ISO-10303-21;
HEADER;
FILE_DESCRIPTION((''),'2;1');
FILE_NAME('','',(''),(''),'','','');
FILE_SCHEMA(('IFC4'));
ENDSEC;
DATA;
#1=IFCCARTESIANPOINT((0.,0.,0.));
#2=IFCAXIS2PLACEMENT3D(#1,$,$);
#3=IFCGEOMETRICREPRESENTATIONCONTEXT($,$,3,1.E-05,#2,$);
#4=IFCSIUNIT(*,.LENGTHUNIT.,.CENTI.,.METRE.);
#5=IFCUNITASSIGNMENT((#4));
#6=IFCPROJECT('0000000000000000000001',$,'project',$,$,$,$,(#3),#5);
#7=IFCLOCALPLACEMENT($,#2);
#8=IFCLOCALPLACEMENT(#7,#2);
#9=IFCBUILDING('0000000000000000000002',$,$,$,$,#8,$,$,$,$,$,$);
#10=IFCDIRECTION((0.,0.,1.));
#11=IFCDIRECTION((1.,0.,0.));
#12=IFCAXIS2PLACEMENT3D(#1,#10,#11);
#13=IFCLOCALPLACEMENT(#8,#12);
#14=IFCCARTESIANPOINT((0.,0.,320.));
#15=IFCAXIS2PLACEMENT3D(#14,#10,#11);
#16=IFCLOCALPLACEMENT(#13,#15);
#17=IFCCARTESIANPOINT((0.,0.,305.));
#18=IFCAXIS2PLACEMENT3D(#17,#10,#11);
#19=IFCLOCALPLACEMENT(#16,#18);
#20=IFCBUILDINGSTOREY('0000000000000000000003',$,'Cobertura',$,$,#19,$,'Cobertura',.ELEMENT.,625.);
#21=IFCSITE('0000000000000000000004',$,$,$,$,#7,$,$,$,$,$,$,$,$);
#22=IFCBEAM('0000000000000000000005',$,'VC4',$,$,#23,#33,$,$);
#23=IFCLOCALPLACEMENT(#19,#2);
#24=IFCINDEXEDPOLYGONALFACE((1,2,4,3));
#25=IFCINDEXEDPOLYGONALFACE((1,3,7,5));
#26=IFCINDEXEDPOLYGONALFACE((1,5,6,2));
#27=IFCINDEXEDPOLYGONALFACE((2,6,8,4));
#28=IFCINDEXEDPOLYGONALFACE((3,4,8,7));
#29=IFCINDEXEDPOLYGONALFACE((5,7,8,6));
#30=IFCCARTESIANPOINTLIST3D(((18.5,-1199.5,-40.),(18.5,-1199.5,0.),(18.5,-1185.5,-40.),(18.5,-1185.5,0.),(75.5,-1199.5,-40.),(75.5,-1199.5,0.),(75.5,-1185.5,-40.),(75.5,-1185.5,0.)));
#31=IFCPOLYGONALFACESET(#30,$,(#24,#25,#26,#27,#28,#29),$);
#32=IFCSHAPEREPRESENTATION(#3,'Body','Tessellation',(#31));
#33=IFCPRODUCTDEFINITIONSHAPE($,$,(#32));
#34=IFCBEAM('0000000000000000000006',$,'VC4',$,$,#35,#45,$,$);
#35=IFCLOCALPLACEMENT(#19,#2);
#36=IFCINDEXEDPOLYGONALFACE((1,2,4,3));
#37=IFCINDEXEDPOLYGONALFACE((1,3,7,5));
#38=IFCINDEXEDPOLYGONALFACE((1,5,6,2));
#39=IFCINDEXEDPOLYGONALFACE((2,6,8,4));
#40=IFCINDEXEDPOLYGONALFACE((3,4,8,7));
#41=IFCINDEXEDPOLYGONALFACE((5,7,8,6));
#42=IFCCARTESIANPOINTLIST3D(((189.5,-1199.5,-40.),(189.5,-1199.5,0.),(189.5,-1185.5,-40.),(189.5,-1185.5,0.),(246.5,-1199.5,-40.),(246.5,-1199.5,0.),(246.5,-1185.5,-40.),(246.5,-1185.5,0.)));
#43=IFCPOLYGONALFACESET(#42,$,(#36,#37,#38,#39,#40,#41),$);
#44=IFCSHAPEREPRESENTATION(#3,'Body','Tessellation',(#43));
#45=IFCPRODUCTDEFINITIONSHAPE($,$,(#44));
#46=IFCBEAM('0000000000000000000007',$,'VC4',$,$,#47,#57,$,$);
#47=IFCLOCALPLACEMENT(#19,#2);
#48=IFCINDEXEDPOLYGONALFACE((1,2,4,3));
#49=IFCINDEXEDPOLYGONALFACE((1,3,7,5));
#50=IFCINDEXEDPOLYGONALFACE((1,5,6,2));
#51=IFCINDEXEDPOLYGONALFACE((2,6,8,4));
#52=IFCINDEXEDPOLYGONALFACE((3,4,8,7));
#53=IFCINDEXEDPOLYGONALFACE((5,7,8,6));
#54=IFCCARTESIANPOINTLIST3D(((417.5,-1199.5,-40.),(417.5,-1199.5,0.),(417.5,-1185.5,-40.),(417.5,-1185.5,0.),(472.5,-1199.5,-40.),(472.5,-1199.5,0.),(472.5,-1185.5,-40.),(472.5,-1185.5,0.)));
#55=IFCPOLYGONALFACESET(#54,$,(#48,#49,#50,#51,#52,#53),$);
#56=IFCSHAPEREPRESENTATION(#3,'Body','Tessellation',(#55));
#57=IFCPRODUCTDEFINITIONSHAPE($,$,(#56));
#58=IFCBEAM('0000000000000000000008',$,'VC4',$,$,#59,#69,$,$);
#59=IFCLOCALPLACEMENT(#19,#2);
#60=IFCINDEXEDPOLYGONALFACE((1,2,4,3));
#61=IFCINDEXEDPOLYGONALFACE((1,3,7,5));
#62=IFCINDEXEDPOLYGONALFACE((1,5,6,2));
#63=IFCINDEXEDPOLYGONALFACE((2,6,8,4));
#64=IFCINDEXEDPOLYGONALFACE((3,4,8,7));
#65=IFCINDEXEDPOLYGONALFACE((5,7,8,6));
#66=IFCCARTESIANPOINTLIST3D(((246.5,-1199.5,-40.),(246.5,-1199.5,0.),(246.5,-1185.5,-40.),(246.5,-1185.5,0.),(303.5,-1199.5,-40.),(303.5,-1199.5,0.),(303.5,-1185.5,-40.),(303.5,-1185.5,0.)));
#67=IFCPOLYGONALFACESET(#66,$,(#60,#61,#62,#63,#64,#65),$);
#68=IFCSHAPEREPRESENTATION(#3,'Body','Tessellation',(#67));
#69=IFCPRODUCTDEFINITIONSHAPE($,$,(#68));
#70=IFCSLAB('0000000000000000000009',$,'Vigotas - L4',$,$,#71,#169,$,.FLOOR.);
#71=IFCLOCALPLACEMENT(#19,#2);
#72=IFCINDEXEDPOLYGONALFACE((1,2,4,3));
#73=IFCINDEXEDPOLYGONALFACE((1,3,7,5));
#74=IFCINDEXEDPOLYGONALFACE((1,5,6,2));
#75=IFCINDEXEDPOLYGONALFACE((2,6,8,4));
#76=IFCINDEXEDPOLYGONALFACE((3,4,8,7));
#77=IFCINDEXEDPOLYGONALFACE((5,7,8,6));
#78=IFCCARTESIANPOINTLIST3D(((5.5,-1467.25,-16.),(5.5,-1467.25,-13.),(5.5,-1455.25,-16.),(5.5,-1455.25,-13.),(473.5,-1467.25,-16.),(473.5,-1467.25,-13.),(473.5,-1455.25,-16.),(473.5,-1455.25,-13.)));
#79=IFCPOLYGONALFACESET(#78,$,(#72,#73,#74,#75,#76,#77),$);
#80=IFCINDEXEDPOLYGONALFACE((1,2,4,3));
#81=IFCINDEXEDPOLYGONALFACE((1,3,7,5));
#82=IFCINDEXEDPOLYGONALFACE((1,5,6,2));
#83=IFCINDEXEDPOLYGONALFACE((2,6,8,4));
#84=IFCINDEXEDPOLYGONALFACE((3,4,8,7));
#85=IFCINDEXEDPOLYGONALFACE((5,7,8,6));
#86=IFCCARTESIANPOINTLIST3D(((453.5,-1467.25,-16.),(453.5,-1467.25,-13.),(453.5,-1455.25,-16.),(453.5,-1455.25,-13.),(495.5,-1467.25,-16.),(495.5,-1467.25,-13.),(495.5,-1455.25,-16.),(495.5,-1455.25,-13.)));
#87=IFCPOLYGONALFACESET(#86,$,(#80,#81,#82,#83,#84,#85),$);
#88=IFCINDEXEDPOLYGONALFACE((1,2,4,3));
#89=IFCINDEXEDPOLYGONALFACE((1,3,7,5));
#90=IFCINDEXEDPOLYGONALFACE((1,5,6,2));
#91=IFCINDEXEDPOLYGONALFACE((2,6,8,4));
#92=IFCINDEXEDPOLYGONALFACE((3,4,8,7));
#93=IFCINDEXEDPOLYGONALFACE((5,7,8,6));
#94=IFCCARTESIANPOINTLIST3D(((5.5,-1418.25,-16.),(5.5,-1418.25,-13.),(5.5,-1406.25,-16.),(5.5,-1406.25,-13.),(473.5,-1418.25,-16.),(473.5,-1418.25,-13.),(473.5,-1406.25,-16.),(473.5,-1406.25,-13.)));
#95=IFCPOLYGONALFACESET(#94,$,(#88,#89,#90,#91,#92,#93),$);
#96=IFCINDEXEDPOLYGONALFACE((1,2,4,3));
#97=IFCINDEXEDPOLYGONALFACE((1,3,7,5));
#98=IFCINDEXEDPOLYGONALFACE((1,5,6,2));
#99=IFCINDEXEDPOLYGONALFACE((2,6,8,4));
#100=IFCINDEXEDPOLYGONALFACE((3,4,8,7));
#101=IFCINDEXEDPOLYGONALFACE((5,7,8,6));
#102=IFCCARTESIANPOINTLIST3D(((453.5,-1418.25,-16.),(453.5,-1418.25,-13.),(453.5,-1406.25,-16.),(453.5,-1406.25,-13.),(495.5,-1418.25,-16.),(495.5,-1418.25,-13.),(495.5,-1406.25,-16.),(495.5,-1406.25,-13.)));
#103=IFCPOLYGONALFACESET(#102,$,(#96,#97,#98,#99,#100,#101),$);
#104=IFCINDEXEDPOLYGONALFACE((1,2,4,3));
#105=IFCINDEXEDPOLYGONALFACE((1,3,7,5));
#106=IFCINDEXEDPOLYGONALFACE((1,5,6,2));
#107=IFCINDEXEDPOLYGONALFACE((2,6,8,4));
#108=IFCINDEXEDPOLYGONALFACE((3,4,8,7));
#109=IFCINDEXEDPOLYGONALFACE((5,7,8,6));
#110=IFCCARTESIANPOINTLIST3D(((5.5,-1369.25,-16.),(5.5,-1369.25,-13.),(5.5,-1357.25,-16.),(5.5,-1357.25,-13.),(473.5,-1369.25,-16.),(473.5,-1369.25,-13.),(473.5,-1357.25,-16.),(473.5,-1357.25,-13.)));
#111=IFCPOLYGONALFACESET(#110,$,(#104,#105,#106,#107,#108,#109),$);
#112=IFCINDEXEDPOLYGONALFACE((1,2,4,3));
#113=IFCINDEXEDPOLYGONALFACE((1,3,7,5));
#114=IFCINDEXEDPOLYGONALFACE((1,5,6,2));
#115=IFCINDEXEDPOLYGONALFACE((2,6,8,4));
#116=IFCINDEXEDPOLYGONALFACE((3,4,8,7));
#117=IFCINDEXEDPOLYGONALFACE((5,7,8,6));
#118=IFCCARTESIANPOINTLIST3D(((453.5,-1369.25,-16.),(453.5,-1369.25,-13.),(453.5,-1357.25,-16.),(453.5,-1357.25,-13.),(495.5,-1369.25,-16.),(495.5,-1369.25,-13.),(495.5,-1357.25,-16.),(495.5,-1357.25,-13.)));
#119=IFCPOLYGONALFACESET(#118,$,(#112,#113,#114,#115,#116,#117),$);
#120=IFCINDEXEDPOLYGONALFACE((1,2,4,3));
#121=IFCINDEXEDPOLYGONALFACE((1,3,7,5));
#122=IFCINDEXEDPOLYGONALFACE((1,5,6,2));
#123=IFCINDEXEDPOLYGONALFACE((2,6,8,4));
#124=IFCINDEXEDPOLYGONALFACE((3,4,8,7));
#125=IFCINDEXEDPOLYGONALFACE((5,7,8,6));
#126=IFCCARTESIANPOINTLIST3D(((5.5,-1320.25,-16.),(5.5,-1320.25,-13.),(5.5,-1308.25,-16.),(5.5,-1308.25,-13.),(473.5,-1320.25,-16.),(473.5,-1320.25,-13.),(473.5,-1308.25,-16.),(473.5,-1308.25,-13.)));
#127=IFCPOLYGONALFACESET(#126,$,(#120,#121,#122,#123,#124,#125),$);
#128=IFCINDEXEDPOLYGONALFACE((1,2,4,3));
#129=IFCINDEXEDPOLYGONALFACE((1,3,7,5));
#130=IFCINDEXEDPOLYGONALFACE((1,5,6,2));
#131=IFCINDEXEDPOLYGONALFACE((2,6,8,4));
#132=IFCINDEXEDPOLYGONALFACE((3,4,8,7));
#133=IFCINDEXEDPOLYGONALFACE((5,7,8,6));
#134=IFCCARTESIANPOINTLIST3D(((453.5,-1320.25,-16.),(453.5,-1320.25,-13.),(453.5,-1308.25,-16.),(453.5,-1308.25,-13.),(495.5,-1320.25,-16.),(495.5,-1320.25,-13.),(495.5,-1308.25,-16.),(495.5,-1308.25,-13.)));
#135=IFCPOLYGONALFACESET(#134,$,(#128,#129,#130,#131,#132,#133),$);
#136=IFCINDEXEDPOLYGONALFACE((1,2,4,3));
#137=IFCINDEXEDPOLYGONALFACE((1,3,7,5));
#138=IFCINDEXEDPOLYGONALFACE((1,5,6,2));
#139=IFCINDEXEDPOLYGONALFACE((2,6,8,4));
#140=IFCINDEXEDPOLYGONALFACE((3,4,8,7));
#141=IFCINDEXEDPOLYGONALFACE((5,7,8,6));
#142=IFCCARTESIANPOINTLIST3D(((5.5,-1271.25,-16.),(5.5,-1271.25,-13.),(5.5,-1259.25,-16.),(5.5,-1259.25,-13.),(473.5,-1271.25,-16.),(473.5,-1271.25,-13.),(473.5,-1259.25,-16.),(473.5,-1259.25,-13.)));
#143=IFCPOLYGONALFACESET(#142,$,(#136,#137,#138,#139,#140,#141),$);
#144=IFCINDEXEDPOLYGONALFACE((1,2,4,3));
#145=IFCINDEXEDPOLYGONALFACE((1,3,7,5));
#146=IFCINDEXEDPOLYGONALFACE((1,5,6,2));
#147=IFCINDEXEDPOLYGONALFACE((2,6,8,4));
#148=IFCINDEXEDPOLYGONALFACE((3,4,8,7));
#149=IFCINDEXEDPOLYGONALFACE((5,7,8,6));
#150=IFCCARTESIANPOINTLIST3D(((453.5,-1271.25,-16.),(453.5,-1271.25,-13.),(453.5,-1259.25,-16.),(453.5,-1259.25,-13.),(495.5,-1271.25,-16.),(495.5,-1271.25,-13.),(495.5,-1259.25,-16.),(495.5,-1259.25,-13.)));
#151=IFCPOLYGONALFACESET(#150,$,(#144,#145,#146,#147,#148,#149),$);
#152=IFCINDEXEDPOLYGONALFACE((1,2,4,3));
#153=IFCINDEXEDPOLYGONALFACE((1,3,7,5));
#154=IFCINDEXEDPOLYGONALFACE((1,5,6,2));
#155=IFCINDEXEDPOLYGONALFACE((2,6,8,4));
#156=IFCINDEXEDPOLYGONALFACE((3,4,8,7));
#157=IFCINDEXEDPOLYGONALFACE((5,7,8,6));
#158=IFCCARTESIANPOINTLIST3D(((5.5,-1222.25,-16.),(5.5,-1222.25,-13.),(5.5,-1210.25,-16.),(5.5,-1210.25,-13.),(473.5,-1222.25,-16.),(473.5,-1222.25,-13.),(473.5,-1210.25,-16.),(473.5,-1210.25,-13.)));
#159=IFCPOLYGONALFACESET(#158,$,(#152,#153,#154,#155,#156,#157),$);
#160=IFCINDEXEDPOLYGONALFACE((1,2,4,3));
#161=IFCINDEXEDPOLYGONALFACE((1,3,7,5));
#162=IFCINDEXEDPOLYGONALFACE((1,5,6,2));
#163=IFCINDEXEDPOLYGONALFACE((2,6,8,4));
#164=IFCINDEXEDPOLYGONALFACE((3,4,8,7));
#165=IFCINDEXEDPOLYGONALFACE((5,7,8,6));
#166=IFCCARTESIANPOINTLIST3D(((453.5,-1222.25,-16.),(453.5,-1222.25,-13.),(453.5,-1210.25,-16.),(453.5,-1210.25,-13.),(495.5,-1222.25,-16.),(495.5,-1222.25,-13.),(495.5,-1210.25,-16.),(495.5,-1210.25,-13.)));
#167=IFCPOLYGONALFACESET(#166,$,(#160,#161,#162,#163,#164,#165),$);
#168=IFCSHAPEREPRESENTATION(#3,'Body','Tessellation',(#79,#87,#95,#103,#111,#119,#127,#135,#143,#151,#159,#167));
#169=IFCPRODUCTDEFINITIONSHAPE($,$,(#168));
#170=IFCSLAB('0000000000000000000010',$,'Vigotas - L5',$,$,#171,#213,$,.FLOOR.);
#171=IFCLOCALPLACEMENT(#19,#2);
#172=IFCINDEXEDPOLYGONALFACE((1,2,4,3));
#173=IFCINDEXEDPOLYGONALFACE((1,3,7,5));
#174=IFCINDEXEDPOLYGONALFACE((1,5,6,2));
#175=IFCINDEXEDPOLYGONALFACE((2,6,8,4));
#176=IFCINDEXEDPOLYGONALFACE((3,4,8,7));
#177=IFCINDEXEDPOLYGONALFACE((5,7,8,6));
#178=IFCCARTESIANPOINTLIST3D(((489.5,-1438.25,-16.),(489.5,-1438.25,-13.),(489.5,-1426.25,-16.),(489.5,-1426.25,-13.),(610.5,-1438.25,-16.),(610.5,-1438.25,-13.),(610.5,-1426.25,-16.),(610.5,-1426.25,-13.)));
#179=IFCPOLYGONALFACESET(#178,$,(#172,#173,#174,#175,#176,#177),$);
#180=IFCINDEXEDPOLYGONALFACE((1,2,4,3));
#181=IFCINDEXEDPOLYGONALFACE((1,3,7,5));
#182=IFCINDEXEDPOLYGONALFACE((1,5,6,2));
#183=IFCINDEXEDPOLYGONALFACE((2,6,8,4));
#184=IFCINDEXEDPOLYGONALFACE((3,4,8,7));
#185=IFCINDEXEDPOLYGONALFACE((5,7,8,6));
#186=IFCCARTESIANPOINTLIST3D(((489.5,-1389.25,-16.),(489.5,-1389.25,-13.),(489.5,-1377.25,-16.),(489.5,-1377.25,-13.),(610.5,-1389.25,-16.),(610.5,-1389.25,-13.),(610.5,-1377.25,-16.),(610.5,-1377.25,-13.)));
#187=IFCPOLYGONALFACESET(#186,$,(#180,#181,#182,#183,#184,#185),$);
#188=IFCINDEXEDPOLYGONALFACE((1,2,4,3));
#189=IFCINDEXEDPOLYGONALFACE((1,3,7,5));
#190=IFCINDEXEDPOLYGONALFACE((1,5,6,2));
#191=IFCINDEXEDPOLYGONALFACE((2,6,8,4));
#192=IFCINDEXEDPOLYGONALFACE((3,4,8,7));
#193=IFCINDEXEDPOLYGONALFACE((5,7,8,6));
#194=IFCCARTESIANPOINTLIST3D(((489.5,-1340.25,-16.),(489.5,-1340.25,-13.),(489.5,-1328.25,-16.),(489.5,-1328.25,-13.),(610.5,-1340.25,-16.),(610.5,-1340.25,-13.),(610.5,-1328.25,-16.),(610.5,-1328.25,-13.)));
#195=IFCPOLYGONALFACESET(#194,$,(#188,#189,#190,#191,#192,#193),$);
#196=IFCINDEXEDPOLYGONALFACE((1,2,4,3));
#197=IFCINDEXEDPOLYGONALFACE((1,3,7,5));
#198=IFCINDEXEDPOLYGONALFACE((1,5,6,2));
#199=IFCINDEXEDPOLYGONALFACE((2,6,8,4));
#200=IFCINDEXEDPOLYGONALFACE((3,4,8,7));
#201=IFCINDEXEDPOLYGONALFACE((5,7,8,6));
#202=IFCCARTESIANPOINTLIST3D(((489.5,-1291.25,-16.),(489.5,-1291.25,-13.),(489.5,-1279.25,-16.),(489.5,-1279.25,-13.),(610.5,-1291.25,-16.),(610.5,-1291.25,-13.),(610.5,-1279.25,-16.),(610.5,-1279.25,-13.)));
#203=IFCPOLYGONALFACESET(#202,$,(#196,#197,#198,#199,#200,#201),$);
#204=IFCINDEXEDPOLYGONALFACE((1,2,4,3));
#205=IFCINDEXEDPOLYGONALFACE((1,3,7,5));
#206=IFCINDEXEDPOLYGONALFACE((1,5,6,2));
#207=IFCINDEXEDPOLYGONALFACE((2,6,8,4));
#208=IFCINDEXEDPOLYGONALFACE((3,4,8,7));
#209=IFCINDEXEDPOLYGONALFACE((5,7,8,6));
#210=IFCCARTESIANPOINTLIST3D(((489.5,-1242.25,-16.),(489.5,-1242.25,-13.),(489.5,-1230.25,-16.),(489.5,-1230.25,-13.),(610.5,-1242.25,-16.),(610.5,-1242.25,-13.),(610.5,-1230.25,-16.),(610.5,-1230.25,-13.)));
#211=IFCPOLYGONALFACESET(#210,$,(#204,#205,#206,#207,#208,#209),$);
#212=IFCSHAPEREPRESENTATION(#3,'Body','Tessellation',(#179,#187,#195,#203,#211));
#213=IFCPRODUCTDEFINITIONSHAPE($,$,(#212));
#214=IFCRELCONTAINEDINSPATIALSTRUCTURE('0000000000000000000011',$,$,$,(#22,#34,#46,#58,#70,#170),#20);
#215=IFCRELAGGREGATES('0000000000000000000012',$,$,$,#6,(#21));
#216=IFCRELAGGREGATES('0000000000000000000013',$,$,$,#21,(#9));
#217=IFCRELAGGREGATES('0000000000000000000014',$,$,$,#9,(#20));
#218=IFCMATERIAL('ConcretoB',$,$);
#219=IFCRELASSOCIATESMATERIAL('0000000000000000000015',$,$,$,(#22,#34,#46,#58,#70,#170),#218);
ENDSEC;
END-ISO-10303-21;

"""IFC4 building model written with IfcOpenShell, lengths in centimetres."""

from ifc_helpers import new_model, si_unit, frame, origin, origin_with_axes, place, context, project, spatial, polyline, outline, extrude, material, element, save


model = new_model("IFC4")

# Units and contexts
context_of_model = context(None, 3, precision=1e-05, world=origin())
ifc_project = project(units=[si_unit("LENGTHUNIT", "METRE", prefix="CENTI")], contexts=[context_of_model])

# Site, building, storey
site_placement = place(None, origin())
site = spatial("IfcSite", under=ifc_project, at=site_placement)
building_placement = place(site_placement, origin())
building = spatial("IfcBuilding", under=site, at=building_placement)
placement_1 = place(building_placement, origin_with_axes())
placement_2 = place(placement_1, frame((0.0, 0.0, 320.0), z_axis=(0.0, 0.0, 1.0), x_axis=(1.0, 0.0, 0.0)))
storey_placement = place(placement_2, frame((0.0, 0.0, 305.0), z_axis=(0.0, 0.0, 1.0), x_axis=(1.0, 0.0, 0.0)))
storey = spatial("IfcBuildingStorey", under=building, at=storey_placement, Name="Cobertura", LongName="Cobertura", CompositionType="ELEMENT", Elevation=625.0)

# Shared definitions
ifc_material_1 = material(Name="ConcretoB")

# Beams
for number, where, z_axis, x_axis, name in (
    (1, (47.0, -1192.5, 0.0), (0.0, 0.0, 1.0), (1.0, 0.0, 0.0), "VC4"),
    (2, (218.0, -1192.5, 0.0), (0.0, 0.0, 1.0), (1.0, 0.0, 0.0), "VC4"),
):
    element("IfcBeam", number, at=place(storey_placement, frame(where, z_axis=z_axis, x_axis=x_axis)), inside=storey, material=ifc_material_1, Name=name, context=context_of_model, shape_type="SolidModel", body=[
        extrude(outline(polyline([(-7.0, -20.0), (7.0, -20.0), (7.0, 20.0), (-7.0, 20.0), (-7.0, -20.0)])), frame((-28.5, 0.0, -20.0), z_axis=(1.0, 0.0, 0.0), x_axis=(0.0, -1.0, 0.0)), (0.0, 0.0, 1.0), 57.0),
    ])
beam_1_placement = place(storey_placement, frame((445.0, -1192.5, 0.0), z_axis=(0.0, 0.0, 1.0), x_axis=(1.0, 0.0, 0.0)))
element("IfcBeam", 3, at=beam_1_placement, inside=storey, material=ifc_material_1, Name="VC4", context=context_of_model, shape_type="SolidModel", body=[
    extrude(outline(polyline([(-7.0, -20.0), (7.0, -20.0), (7.0, 20.0), (-7.0, 20.0), (-7.0, -20.0)])), frame((-27.5, 0.0, -20.0), z_axis=(1.0, 0.0, 0.0), x_axis=(0.0, -1.0, 0.0)), (0.0, 0.0, 1.0), 55.0),
])
beam_2_placement = place(storey_placement, frame((275.0, -1192.5, 0.0), z_axis=(0.0, 0.0, 1.0), x_axis=(1.0, 0.0, 0.0)))
element("IfcBeam", 4, at=beam_2_placement, inside=storey, material=ifc_material_1, Name="VC4", context=context_of_model, shape_type="SolidModel", body=[
    extrude(outline(polyline([(-7.0, -20.0), (7.0, -20.0), (7.0, 20.0), (-7.0, 20.0), (-7.0, -20.0)])), frame((-28.5, 0.0, -20.0), z_axis=(1.0, 0.0, 0.0), x_axis=(0.0, -1.0, 0.0)), (0.0, 0.0, 1.0), 57.0),
])

# Slabs
slab_1_placement = place(storey_placement, frame((250.5, -1338.75, -13.0), z_axis=(0.0, 0.0, 1.0), x_axis=(1.0, 0.0, 0.0)))
element("IfcSlab", 5, at=slab_1_placement, inside=storey, material=ifc_material_1, Name="Vigotas - L4", PredefinedType="FLOOR", context=context_of_model, shape_type="SolidModel", body=[
    extrude(outline(polyline([(6.0, 1.5), (-6.0, 1.5), (-6.0, -1.5), (6.0, -1.5), (6.0, 1.5), (6.0, 1.5)])), frame((-245.0, -122.5, -1.5), z_axis=(1.0, 0.0, 0.0), x_axis=(0.0, -1.0, 0.0)), (0.0, 0.0, 1.0), 468.0),
    extrude(outline(polyline([(6.0, 1.5), (-6.0, 1.5), (-6.0, -1.5), (6.0, -1.5), (6.0, 1.5), (6.0, 1.5)])), frame((203.0, -122.5, -1.5), z_axis=(1.0, 0.0, 0.0), x_axis=(0.0, -1.0, 0.0)), (0.0, 0.0, 1.0), 42.0),
    extrude(outline(polyline([(6.0, 1.5), (-6.0, 1.5), (-6.0, -1.5), (6.0, -1.5), (6.0, 1.5), (6.0, 1.5)])), frame((-245.0, -73.5, -1.5), z_axis=(1.0, 0.0, 0.0), x_axis=(0.0, -1.0, 0.0)), (0.0, 0.0, 1.0), 468.0),
    extrude(outline(polyline([(6.0, 1.5), (-6.0, 1.5), (-6.0, -1.5), (6.0, -1.5), (6.0, 1.5), (6.0, 1.5)])), frame((203.0, -73.5, -1.5), z_axis=(1.0, 0.0, 0.0), x_axis=(0.0, -1.0, 0.0)), (0.0, 0.0, 1.0), 42.0),
    extrude(outline(polyline([(6.0, 1.5), (-6.0, 1.5), (-6.0, -1.5), (6.0, -1.5), (6.0, 1.5), (6.0, 1.5)])), frame((-245.0, -24.5, -1.5), z_axis=(1.0, 0.0, 0.0), x_axis=(0.0, -1.0, 0.0)), (0.0, 0.0, 1.0), 468.0),
    extrude(outline(polyline([(6.0, 1.5), (-6.0, 1.5), (-6.0, -1.5), (6.0, -1.5), (6.0, 1.5), (6.0, 1.5)])), frame((203.0, -24.5, -1.5), z_axis=(1.0, 0.0, 0.0), x_axis=(0.0, -1.0, 0.0)), (0.0, 0.0, 1.0), 42.0),
    extrude(outline(polyline([(6.0, 1.5), (-6.0, 1.5), (-6.0, -1.5), (6.0, -1.5), (6.0, 1.5), (6.0, 1.5)])), frame((-245.0, 24.5, -1.5), z_axis=(1.0, 0.0, 0.0), x_axis=(0.0, -1.0, 0.0)), (0.0, 0.0, 1.0), 468.0),
    extrude(outline(polyline([(6.0, 1.5), (-6.0, 1.5), (-6.0, -1.5), (6.0, -1.5), (6.0, 1.5), (6.0, 1.5)])), frame((203.0, 24.5, -1.5), z_axis=(1.0, 0.0, 0.0), x_axis=(0.0, -1.0, 0.0)), (0.0, 0.0, 1.0), 42.0),
    extrude(outline(polyline([(6.0, 1.5), (-6.0, 1.5), (-6.0, -1.5), (6.0, -1.5), (6.0, 1.5), (6.0, 1.5)])), frame((-245.0, 73.5, -1.5), z_axis=(1.0, 0.0, 0.0), x_axis=(0.0, -1.0, 0.0)), (0.0, 0.0, 1.0), 468.0),
    extrude(outline(polyline([(6.0, 1.5), (-6.0, 1.5), (-6.0, -1.5), (6.0, -1.5), (6.0, 1.5), (6.0, 1.5)])), frame((203.0, 73.5, -1.5), z_axis=(1.0, 0.0, 0.0), x_axis=(0.0, -1.0, 0.0)), (0.0, 0.0, 1.0), 42.0),
    extrude(outline(polyline([(6.0, 1.5), (-6.0, 1.5), (-6.0, -1.5), (6.0, -1.5), (6.0, 1.5), (6.0, 1.5)])), frame((-245.0, 122.5, -1.5), z_axis=(1.0, 0.0, 0.0), x_axis=(0.0, -1.0, 0.0)), (0.0, 0.0, 1.0), 468.0),
    extrude(outline(polyline([(6.0, 1.5), (-6.0, 1.5), (-6.0, -1.5), (6.0, -1.5), (6.0, 1.5), (6.0, 1.5)])), frame((203.0, 122.5, -1.5), z_axis=(1.0, 0.0, 0.0), x_axis=(0.0, -1.0, 0.0)), (0.0, 0.0, 1.0), 42.0),
])
slab_2_placement = place(storey_placement, frame((550.0, -1334.25, -13.0), z_axis=(0.0, 0.0, 1.0), x_axis=(1.0, 0.0, 0.0)))
element("IfcSlab", 6, at=slab_2_placement, inside=storey, material=ifc_material_1, Name="Vigotas - L5", PredefinedType="FLOOR", context=context_of_model, shape_type="SolidModel", body=[
    extrude(outline(polyline([(6.0, 1.5), (-6.0, 1.5), (-6.0, -1.5), (6.0, -1.5), (6.0, 1.5), (6.0, 1.5)])), frame((-60.5, -98.0, -1.5), z_axis=(1.0, 0.0, 0.0), x_axis=(0.0, -1.0, 0.0)), (0.0, 0.0, 1.0), 121.0),
    extrude(outline(polyline([(6.0, 1.5), (-6.0, 1.5), (-6.0, -1.5), (6.0, -1.5), (6.0, 1.5), (6.0, 1.5)])), frame((-60.5, -49.0, -1.5), z_axis=(1.0, 0.0, 0.0), x_axis=(0.0, -1.0, 0.0)), (0.0, 0.0, 1.0), 121.0),
    extrude(outline(polyline([(6.0, 1.5), (-6.0, 1.5), (-6.0, -1.5), (6.0, -1.5), (6.0, 1.5), (6.0, 1.5)])), frame((-60.5, 0.0, -1.5), z_axis=(1.0, 0.0, 0.0), x_axis=(0.0, -1.0, 0.0)), (0.0, 0.0, 1.0), 121.0),
    extrude(outline(polyline([(6.0, 1.5), (-6.0, 1.5), (-6.0, -1.5), (6.0, -1.5), (6.0, 1.5), (6.0, 1.5)])), frame((-60.5, 49.0, -1.5), z_axis=(1.0, 0.0, 0.0), x_axis=(0.0, -1.0, 0.0)), (0.0, 0.0, 1.0), 121.0),
    extrude(outline(polyline([(6.0, 1.5), (-6.0, 1.5), (-6.0, -1.5), (6.0, -1.5), (6.0, 1.5), (6.0, 1.5)])), frame((-60.5, 98.0, -1.5), z_axis=(1.0, 0.0, 0.0), x_axis=(0.0, -1.0, 0.0)), (0.0, 0.0, 1.0), 121.0),
])

save(model, "model.ifc")
